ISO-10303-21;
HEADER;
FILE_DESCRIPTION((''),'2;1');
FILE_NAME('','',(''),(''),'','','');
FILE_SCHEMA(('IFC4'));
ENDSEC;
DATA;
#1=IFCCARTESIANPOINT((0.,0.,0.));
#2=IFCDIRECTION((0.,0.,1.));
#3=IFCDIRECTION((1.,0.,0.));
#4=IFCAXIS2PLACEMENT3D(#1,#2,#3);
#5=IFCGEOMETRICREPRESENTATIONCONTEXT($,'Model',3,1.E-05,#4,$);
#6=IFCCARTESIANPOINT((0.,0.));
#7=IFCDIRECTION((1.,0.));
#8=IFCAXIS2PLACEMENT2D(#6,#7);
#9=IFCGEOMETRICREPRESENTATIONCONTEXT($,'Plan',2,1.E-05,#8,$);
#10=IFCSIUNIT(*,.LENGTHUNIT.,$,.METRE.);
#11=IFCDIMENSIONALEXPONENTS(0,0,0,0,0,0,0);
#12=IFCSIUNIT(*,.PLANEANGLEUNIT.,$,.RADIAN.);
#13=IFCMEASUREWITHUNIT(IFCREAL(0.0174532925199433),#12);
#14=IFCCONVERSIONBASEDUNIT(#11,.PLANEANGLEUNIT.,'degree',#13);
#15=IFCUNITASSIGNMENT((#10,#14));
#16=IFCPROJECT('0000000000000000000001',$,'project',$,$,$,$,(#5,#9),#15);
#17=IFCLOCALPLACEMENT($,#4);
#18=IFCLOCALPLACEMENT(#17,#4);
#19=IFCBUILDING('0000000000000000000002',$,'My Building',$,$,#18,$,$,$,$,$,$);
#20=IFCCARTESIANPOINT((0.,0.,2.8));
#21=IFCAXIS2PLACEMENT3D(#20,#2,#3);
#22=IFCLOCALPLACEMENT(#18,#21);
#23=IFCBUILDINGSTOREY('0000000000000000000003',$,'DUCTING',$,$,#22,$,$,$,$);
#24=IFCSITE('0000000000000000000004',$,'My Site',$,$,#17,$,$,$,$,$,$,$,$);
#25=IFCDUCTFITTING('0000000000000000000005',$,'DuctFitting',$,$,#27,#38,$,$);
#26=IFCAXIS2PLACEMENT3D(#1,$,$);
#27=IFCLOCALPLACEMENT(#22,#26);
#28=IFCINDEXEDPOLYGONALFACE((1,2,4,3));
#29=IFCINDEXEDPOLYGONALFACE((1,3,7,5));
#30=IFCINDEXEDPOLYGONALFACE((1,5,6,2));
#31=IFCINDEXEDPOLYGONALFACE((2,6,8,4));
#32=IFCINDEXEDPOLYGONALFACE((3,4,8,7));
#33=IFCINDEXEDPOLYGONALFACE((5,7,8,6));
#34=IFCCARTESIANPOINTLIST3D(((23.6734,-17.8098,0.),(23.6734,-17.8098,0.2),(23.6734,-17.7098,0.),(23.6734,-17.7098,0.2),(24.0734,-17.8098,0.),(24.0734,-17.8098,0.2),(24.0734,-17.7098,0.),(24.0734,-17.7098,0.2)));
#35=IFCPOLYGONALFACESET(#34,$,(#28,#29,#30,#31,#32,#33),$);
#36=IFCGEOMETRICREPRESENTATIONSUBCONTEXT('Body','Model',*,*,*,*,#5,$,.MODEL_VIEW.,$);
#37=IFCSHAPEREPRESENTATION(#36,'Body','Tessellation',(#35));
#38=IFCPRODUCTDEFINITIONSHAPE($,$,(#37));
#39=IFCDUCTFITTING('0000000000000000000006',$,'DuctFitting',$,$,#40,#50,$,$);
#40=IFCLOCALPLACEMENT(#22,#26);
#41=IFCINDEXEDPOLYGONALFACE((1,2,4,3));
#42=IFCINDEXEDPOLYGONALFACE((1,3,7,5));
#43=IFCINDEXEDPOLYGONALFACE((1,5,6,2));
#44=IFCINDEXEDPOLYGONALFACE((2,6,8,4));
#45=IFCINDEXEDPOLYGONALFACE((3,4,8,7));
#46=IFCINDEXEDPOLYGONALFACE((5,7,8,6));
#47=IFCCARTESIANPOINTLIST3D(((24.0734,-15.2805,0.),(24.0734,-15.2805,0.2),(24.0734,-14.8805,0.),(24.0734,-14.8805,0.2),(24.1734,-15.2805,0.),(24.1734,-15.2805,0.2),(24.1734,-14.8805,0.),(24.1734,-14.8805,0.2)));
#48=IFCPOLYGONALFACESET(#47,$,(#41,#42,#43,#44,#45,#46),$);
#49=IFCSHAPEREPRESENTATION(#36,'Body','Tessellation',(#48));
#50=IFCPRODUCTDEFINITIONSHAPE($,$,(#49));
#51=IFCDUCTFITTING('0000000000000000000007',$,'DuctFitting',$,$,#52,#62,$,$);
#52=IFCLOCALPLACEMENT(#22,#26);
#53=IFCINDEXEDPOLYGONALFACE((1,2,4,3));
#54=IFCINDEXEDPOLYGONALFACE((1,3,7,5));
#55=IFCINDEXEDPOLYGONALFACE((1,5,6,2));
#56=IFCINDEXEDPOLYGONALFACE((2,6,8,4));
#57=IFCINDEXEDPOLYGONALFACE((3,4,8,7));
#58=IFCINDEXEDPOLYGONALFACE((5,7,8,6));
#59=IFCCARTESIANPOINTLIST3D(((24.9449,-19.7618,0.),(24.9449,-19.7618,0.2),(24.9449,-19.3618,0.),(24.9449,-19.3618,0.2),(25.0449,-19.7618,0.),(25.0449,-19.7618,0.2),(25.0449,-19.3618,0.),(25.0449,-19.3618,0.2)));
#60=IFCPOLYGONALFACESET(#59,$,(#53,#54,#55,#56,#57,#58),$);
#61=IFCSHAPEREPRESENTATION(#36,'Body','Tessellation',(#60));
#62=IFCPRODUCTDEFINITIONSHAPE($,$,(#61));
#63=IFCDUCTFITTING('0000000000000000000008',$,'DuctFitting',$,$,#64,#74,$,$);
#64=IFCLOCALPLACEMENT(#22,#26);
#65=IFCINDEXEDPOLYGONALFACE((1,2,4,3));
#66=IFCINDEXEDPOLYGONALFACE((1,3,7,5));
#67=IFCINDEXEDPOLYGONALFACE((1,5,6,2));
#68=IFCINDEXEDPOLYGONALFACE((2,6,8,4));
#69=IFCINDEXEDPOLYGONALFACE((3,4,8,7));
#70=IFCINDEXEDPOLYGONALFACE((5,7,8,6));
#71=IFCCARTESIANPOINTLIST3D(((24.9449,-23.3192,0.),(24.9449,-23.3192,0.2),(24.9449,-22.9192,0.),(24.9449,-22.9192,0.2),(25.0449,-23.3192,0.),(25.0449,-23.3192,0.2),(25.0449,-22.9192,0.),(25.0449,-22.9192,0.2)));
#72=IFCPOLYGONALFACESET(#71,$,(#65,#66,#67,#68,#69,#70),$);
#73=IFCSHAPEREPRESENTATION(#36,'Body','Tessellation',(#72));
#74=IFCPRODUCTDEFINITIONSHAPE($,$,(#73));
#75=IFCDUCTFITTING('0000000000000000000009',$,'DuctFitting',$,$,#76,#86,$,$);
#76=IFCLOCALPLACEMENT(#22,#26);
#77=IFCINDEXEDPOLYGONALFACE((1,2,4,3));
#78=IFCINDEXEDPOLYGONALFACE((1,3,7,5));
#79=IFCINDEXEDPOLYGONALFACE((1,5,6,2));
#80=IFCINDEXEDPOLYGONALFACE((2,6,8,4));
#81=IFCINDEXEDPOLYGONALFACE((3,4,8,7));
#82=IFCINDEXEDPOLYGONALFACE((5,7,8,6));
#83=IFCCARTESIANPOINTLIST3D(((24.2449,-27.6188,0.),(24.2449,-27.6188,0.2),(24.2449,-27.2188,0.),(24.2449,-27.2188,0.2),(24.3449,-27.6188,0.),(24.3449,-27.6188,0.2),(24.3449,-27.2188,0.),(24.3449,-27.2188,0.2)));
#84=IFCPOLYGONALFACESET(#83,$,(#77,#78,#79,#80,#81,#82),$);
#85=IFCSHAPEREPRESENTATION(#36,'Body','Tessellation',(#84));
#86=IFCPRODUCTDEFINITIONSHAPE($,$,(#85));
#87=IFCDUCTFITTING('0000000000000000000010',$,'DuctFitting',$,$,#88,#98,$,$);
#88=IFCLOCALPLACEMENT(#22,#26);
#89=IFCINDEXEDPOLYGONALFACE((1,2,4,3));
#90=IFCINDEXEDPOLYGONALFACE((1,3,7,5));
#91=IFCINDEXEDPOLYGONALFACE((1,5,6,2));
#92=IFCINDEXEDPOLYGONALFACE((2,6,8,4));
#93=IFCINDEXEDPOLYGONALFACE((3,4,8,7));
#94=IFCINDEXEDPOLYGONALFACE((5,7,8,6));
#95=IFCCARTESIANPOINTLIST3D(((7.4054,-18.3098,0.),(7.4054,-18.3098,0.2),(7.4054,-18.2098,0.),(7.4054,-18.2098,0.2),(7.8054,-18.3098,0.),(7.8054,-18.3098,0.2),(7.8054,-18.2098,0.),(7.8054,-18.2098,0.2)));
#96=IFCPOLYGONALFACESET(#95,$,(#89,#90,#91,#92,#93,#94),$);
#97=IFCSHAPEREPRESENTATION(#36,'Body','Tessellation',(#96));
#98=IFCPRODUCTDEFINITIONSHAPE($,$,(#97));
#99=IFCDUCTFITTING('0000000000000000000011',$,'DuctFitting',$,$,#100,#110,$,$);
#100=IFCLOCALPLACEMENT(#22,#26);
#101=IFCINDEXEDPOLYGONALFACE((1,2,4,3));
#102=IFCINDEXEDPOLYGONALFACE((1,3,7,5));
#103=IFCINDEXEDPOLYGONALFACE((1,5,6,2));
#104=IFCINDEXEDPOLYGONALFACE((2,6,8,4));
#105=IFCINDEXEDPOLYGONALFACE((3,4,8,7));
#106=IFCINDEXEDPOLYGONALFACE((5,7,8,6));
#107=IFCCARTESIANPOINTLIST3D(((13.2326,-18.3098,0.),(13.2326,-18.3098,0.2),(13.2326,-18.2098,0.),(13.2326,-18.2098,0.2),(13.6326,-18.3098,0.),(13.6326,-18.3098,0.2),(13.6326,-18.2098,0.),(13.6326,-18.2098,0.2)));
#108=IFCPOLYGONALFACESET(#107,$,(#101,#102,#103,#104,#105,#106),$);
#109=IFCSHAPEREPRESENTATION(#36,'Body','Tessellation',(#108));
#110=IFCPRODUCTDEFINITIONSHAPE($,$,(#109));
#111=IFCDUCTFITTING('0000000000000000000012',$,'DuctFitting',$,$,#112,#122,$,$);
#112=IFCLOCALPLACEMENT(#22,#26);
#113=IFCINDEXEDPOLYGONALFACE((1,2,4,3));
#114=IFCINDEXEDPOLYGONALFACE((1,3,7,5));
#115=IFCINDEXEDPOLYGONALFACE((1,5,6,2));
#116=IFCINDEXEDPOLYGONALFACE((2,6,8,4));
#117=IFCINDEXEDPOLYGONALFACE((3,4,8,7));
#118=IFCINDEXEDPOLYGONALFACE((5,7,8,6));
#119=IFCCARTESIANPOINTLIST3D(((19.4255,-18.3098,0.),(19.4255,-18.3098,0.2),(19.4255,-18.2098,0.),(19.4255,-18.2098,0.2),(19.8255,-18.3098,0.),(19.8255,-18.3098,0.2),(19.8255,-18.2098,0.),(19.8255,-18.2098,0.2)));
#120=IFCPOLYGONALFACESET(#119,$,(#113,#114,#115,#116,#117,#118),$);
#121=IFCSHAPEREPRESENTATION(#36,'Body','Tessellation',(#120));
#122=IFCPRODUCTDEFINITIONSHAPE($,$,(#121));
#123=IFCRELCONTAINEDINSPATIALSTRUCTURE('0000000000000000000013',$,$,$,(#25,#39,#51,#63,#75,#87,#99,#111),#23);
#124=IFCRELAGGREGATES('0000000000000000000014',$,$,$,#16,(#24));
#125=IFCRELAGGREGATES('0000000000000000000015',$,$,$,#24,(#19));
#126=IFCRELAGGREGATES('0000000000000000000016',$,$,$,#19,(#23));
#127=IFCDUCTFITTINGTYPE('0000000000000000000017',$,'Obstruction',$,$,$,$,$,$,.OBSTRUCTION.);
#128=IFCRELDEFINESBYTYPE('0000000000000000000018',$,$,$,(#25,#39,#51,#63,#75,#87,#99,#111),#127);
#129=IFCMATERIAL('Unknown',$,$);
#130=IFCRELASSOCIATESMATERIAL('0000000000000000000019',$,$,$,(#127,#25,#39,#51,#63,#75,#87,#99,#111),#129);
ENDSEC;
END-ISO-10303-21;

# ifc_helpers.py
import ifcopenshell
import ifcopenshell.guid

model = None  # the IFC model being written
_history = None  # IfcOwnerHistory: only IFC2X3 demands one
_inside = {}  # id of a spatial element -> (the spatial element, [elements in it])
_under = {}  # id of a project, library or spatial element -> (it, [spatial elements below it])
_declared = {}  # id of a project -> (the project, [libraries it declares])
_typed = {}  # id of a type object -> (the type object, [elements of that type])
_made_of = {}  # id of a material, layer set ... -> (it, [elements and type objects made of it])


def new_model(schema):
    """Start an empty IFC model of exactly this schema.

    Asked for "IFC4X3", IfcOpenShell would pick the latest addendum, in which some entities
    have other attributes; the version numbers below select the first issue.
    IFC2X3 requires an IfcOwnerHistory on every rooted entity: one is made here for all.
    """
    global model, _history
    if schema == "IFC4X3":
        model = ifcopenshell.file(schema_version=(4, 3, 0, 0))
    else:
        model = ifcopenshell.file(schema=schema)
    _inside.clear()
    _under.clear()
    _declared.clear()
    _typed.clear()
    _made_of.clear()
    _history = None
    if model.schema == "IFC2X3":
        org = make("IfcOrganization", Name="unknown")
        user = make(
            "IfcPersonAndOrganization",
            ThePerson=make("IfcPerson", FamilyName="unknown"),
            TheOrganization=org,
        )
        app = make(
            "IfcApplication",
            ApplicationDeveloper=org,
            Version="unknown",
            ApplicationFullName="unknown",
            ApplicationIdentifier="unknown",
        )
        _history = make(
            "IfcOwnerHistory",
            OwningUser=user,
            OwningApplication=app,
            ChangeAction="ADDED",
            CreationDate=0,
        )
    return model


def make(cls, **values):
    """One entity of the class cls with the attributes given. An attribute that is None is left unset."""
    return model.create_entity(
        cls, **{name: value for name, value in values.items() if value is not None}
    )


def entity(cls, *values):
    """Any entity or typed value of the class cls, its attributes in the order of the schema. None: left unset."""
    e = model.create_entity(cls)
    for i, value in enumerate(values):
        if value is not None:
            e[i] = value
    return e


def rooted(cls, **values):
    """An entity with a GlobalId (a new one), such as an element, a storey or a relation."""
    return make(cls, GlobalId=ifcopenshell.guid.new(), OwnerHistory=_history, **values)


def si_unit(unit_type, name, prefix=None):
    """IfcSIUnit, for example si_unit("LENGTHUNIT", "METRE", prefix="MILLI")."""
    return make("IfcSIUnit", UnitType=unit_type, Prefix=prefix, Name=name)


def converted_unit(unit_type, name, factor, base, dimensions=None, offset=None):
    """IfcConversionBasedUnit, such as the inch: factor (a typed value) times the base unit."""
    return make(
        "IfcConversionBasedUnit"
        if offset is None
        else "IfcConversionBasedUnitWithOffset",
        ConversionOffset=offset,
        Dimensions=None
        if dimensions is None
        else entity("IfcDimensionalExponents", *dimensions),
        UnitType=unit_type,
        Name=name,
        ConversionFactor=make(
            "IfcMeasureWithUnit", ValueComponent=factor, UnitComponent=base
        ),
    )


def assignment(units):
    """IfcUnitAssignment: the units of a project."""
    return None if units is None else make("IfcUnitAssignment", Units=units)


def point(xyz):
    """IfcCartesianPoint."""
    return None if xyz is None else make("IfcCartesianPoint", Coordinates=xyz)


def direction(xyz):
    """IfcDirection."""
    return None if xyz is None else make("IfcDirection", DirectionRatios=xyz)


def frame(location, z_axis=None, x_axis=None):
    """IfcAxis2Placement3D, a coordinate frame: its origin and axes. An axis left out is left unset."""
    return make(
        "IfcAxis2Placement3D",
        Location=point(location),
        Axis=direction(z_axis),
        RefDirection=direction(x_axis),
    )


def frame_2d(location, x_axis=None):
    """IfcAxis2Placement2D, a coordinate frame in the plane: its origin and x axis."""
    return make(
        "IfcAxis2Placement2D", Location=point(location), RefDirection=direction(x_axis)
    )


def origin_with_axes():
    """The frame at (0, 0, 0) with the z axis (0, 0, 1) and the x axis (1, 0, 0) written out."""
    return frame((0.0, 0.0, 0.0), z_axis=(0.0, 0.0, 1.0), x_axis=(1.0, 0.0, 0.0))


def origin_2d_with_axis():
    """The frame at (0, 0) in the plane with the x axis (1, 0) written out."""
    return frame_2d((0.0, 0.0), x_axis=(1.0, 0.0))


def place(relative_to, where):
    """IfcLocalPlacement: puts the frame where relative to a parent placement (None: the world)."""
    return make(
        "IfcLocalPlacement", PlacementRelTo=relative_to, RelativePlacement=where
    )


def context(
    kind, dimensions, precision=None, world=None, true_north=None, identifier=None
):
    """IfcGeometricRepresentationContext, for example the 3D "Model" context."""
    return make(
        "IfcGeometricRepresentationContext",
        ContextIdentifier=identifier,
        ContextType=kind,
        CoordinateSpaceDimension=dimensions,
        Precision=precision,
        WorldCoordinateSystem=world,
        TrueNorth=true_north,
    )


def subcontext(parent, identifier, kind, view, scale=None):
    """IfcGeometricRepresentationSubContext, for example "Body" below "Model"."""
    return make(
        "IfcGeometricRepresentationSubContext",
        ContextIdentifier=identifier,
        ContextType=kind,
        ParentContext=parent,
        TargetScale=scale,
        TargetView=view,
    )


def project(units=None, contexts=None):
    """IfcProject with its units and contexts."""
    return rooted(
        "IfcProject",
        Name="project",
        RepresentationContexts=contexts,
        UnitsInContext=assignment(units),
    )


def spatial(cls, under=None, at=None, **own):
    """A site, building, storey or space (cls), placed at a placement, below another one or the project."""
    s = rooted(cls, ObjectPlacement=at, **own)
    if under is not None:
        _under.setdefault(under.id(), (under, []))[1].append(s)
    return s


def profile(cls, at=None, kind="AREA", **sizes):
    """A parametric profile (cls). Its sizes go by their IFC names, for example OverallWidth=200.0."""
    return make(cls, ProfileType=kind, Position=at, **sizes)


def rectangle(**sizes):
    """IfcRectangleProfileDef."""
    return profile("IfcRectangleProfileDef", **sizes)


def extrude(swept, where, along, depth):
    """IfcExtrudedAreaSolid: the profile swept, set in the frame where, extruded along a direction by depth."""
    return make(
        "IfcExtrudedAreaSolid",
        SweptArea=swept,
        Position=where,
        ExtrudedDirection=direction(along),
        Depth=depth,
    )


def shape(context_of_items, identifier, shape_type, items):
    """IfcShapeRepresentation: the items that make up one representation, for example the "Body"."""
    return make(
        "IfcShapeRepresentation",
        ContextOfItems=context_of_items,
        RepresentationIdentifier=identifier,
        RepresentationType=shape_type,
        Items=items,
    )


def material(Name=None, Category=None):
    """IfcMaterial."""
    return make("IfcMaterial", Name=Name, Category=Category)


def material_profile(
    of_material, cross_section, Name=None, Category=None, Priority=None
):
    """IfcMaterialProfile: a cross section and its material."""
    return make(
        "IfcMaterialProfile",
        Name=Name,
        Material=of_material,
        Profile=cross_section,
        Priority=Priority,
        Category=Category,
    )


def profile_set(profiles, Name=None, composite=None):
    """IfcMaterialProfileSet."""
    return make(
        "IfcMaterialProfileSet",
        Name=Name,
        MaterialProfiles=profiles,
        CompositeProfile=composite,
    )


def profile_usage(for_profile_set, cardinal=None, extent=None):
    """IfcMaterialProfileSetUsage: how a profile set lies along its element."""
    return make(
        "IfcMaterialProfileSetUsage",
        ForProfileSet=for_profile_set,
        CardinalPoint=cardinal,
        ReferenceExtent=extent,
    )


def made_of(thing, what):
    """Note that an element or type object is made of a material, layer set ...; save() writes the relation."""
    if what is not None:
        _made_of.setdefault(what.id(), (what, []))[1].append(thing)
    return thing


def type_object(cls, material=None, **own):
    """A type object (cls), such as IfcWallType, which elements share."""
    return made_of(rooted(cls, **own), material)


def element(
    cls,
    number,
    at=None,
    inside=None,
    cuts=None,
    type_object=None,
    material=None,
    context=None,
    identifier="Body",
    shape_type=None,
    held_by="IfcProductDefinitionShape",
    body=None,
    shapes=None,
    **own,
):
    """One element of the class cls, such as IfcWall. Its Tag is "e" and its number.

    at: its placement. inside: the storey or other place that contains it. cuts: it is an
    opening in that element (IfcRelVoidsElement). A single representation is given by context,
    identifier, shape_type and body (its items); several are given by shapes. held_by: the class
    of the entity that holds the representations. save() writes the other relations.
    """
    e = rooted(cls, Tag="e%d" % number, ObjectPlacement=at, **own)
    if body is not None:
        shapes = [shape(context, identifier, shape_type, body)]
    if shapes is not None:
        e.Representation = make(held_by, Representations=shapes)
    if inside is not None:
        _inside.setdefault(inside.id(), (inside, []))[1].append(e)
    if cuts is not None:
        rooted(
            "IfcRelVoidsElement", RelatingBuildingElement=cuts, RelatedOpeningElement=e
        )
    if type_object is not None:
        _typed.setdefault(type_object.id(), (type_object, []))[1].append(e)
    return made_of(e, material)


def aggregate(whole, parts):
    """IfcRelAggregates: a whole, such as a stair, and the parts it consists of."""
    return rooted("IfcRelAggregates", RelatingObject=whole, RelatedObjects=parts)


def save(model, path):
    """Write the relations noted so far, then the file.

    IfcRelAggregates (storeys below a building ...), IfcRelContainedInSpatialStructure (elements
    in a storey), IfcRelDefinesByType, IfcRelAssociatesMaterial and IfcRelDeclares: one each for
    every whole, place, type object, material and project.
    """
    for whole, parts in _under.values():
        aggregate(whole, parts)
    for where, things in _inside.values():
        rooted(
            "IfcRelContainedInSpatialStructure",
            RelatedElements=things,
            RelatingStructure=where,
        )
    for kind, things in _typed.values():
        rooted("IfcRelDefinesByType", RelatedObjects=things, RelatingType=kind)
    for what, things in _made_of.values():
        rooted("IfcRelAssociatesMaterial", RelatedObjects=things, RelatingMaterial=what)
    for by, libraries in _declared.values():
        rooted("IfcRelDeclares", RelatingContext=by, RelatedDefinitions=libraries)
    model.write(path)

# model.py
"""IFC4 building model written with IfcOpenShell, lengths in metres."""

from ifc_helpers import new_model, entity, si_unit, converted_unit, frame, origin_with_axes, origin_2d_with_axis, place, context, subcontext, project, spatial, rectangle, extrude, material, material_profile, profile_set, profile_usage, type_object, element, save


model = new_model("IFC4")

# Units and contexts
model_context = context("Model", 3, precision=1e-05, world=origin_with_axes())
plan_context = context("Plan", 2, precision=1e-05, world=origin_2d_with_axis())
body_context = subcontext(model_context, "Body", "Model", "MODEL_VIEW")
ifc_project = project(units=[si_unit("LENGTHUNIT", "METRE"), converted_unit("PLANEANGLEUNIT", "degree", entity("IfcReal", 0.0174532925199433), si_unit("PLANEANGLEUNIT", "RADIAN"), dimensions=[0, 0, 0, 0, 0, 0, 0])], contexts=[model_context, plan_context])

# Site, building, storey
site_placement = place(None, origin_with_axes())
site = spatial("IfcSite", under=ifc_project, at=site_placement, Name="My Site")
building_placement = place(site_placement, origin_with_axes())
building = spatial("IfcBuilding", under=site, at=building_placement, Name="My Building")
storey_placement = place(building_placement, frame((0.0, 0.0, 2.8), z_axis=(0.0, 0.0, 1.0), x_axis=(1.0, 0.0, 0.0)))
storey = spatial("IfcBuildingStorey", under=building, at=storey_placement, Name="DUCTING")

# Shared definitions
ifc_material = material(Name="Unknown")

# Duct fittings
ifc_material_profile_1 = material_profile(ifc_material, rectangle(XDim=0.4, YDim=0.2))
ifc_profile_set_1 = profile_set([ifc_material_profile_1])
duct_fitting_type_1 = type_object("IfcDuctFittingType", Name="Obstruction", PredefinedType="OBSTRUCTION", material=ifc_profile_set_1)
ifc_profile_usage_1 = profile_usage(ifc_profile_set_1, cardinal=5)
duct_fitting_1_placement = place(storey_placement, frame((23.8734, -17.8098, 0.1), z_axis=(0.0, 1.0, 0.0), x_axis=(-1.0, 0.0, 0.0)))
element("IfcDuctFitting", 1, at=duct_fitting_1_placement, inside=storey, type_object=duct_fitting_type_1, material=ifc_profile_usage_1, Name="DuctFitting", context=body_context, shape_type="SweptSolid", body=[
    extrude(rectangle(XDim=0.4, YDim=0.2), origin_with_axes(), (0.0, 0.0, 1.0), 0.1),
])
ifc_profile_usage_2 = profile_usage(ifc_profile_set_1, cardinal=5)
duct_fitting_2_placement = place(storey_placement, frame((24.0734, -15.0805, 0.1), z_axis=(1.0, 0.0, 0.0), x_axis=(0.0, 1.0, 0.0)))
element("IfcDuctFitting", 2, at=duct_fitting_2_placement, inside=storey, type_object=duct_fitting_type_1, material=ifc_profile_usage_2, Name="DuctFitting", context=body_context, shape_type="SweptSolid", body=[
    extrude(rectangle(XDim=0.4, YDim=0.2), origin_with_axes(), (0.0, 0.0, 1.0), 0.1),
])
ifc_profile_usage_3 = profile_usage(ifc_profile_set_1, cardinal=5)
duct_fitting_3_placement = place(storey_placement, frame((24.9449, -19.5618, 0.1), z_axis=(1.0, 0.0, 0.0), x_axis=(0.0, 1.0, 0.0)))
element("IfcDuctFitting", 3, at=duct_fitting_3_placement, inside=storey, type_object=duct_fitting_type_1, material=ifc_profile_usage_3, Name="DuctFitting", context=body_context, shape_type="SweptSolid", body=[
    extrude(rectangle(XDim=0.4, YDim=0.2), origin_with_axes(), (0.0, 0.0, 1.0), 0.1),
])
ifc_profile_usage_4 = profile_usage(ifc_profile_set_1, cardinal=5)
duct_fitting_4_placement = place(storey_placement, frame((24.9449, -23.1192, 0.1), z_axis=(1.0, 0.0, 0.0), x_axis=(0.0, 1.0, 0.0)))
element("IfcDuctFitting", 4, at=duct_fitting_4_placement, inside=storey, type_object=duct_fitting_type_1, material=ifc_profile_usage_4, Name="DuctFitting", context=body_context, shape_type="SweptSolid", body=[
    extrude(rectangle(XDim=0.4, YDim=0.2), origin_with_axes(), (0.0, 0.0, 1.0), 0.1),
])
ifc_profile_usage_5 = profile_usage(ifc_profile_set_1, cardinal=5)
duct_fitting_5_placement = place(storey_placement, frame((24.2449, -27.4188, 0.1), z_axis=(1.0, 0.0, 0.0), x_axis=(0.0, 1.0, 0.0)))
element("IfcDuctFitting", 5, at=duct_fitting_5_placement, inside=storey, type_object=duct_fitting_type_1, material=ifc_profile_usage_5, Name="DuctFitting", context=body_context, shape_type="SweptSolid", body=[
    extrude(rectangle(XDim=0.4, YDim=0.2), origin_with_axes(), (0.0, 0.0, 1.0), 0.1),
])
ifc_profile_usage_6 = profile_usage(ifc_profile_set_1, cardinal=5)
duct_fitting_6_placement = place(storey_placement, frame((7.6054, -18.2098, 0.1), z_axis=(0.0, -1.0, 0.0), x_axis=(1.0, 0.0, 0.0)))
element("IfcDuctFitting", 6, at=duct_fitting_6_placement, inside=storey, type_object=duct_fitting_type_1, material=ifc_profile_usage_6, Name="DuctFitting", context=body_context, shape_type="SweptSolid", body=[
    extrude(rectangle(XDim=0.4, YDim=0.2), origin_with_axes(), (0.0, 0.0, 1.0), 0.1),
])
ifc_profile_usage_7 = profile_usage(ifc_profile_set_1, cardinal=5)
duct_fitting_7_placement = place(storey_placement, frame((13.4326, -18.2098, 0.1), z_axis=(0.0, -1.0, 0.0), x_axis=(1.0, 0.0, 0.0)))
element("IfcDuctFitting", 7, at=duct_fitting_7_placement, inside=storey, type_object=duct_fitting_type_1, material=ifc_profile_usage_7, Name="DuctFitting", context=body_context, shape_type="SweptSolid", body=[
    extrude(rectangle(XDim=0.4, YDim=0.2), origin_with_axes(), (0.0, 0.0, 1.0), 0.1),
])
ifc_profile_usage_8 = profile_usage(ifc_profile_set_1, cardinal=5)
duct_fitting_8_placement = place(storey_placement, frame((19.6255, -18.2098, 0.1), z_axis=(0.0, -1.0, 0.0), x_axis=(1.0, 0.0, 0.0)))
element("IfcDuctFitting", 8, at=duct_fitting_8_placement, inside=storey, type_object=duct_fitting_type_1, material=ifc_profile_usage_8, Name="DuctFitting", context=body_context, shape_type="SweptSolid", body=[
    extrude(rectangle(XDim=0.4, YDim=0.2), origin_with_axes(), (0.0, 0.0, 1.0), 0.1),
])

save(model, "model.ifc")
